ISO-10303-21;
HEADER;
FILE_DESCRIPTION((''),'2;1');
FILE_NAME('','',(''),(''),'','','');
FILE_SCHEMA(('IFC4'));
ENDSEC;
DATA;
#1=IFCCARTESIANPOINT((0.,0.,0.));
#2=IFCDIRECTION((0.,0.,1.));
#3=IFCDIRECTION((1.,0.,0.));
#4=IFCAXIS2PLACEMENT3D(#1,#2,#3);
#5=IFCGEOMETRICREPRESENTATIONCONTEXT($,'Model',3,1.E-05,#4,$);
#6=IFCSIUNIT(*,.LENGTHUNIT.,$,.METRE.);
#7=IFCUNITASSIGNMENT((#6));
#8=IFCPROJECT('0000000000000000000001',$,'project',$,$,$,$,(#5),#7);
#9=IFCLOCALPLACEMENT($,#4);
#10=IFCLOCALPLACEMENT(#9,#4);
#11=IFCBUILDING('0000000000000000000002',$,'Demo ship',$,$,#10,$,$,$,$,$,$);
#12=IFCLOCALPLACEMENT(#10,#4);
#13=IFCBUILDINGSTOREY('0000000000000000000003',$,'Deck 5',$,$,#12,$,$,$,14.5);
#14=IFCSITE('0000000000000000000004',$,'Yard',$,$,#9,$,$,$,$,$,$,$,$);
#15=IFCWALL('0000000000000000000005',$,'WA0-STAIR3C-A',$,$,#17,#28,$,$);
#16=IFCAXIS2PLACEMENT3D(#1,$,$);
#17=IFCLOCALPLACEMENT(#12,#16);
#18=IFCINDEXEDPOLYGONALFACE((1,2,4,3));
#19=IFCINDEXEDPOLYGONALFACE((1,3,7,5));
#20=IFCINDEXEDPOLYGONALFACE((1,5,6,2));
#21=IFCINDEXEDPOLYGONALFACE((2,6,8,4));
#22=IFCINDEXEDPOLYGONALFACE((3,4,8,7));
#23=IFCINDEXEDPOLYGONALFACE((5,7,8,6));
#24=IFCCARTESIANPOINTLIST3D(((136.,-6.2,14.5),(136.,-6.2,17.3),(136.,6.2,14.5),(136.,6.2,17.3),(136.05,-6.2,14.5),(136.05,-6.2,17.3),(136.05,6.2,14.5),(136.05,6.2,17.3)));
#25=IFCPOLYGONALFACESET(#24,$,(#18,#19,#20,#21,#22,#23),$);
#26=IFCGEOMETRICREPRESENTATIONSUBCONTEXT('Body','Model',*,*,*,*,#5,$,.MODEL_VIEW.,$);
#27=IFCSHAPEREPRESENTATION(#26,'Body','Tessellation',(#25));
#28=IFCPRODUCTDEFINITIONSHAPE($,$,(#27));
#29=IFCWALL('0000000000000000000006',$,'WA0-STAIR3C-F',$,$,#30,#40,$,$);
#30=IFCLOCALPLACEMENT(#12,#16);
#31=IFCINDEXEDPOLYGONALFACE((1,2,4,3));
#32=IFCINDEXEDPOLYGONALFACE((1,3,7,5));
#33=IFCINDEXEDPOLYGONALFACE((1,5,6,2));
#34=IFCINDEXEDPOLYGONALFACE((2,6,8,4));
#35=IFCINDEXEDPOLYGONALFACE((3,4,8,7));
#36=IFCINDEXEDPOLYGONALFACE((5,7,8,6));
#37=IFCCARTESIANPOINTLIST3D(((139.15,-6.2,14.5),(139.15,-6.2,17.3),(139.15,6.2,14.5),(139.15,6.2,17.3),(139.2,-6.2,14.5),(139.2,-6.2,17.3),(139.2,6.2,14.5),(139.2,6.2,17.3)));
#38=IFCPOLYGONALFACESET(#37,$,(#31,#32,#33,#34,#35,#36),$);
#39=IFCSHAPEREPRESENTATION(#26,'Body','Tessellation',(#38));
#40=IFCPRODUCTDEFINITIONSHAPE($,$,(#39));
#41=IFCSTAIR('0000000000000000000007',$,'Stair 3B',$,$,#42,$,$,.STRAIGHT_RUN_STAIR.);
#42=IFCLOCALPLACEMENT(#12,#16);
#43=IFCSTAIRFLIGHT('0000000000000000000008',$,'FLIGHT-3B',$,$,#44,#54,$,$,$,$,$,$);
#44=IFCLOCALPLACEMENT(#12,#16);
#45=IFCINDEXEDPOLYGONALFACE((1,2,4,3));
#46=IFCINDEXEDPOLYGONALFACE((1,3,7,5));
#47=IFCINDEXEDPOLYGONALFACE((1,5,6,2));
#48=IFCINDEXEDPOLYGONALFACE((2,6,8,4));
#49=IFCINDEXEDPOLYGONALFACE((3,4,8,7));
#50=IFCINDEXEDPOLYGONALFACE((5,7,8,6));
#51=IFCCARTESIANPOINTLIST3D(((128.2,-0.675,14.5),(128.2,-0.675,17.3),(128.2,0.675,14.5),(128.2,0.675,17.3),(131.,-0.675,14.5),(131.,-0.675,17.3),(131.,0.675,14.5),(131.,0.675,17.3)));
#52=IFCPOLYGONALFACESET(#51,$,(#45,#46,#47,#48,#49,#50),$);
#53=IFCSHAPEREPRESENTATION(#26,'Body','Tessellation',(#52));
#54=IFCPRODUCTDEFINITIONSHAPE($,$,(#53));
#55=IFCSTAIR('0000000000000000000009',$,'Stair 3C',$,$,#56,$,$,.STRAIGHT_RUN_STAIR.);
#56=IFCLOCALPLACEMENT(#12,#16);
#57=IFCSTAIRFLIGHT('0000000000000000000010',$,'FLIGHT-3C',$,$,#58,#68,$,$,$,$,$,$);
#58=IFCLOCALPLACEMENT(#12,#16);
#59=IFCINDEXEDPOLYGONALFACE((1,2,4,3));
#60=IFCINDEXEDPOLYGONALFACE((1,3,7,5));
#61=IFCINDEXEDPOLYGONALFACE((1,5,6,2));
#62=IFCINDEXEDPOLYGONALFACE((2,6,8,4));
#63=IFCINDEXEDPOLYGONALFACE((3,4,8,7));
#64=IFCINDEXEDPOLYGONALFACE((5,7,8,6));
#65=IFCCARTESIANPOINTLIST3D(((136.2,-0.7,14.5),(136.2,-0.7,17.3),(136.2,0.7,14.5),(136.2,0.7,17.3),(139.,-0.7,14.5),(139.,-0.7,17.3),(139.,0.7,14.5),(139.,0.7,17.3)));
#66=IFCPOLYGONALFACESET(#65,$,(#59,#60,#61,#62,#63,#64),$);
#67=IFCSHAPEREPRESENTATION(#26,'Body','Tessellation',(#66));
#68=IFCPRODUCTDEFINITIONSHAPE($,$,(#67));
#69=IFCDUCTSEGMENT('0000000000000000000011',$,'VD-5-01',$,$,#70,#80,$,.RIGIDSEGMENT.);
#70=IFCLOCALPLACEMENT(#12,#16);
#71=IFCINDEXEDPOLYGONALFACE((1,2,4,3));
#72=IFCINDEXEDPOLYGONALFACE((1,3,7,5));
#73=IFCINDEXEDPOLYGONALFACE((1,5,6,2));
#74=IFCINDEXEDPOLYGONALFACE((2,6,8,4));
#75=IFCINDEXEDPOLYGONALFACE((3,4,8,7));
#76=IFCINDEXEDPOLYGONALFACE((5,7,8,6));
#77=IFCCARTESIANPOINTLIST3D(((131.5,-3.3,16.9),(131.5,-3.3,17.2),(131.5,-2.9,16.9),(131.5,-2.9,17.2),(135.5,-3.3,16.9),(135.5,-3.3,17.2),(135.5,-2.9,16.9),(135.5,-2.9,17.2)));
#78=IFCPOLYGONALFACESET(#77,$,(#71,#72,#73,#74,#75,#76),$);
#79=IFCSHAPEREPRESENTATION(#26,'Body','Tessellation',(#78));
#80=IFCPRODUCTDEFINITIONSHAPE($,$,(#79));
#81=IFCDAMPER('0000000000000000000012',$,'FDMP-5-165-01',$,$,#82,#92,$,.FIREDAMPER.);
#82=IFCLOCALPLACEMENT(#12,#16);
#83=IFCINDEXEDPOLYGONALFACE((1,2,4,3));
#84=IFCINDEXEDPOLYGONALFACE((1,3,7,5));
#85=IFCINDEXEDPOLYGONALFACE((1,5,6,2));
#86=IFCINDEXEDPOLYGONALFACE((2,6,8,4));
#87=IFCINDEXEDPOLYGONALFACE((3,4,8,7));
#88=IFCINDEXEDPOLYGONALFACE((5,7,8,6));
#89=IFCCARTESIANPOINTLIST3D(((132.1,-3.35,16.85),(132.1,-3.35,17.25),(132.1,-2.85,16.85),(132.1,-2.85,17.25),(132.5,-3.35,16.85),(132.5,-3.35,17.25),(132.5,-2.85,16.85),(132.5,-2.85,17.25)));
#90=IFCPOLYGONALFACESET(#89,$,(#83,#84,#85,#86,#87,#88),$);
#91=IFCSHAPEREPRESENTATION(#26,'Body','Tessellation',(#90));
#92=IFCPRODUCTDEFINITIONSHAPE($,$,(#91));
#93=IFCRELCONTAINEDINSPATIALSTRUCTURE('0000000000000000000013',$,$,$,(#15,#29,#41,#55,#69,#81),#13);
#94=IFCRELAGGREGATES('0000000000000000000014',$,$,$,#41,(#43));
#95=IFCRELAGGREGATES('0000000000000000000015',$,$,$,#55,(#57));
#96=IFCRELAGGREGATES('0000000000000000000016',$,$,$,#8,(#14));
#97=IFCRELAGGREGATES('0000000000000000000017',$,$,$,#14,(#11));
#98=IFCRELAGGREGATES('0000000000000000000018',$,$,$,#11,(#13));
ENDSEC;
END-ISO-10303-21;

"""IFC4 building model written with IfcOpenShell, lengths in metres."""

from ifc_helpers import new_model, si_unit, frame, frame_2d, origin, origin_with_axes, place, context, subcontext, project, spatial, rectangle, extrude, element, aggregate, save


model = new_model("IFC4")

# Units and contexts
model_context = context("Model", 3, precision=1e-05, world=origin_with_axes())
body_context = subcontext(model_context, "Body", "Model", "MODEL_VIEW")
ifc_project = project(units=[si_unit("LENGTHUNIT", "METRE")], contexts=[model_context])

# Site, building, storey
site_placement = place(None, origin_with_axes())
site = spatial("IfcSite", under=ifc_project, at=site_placement, Name="Yard")
building_placement = place(site_placement, origin_with_axes())
building = spatial("IfcBuilding", under=site, at=building_placement, Name="Demo ship")
storey_placement = place(building_placement, origin_with_axes())
storey = spatial("IfcBuildingStorey", under=building, at=storey_placement, Name="Deck 5", Elevation=14.5)

# Walls
for number, where, z_axis, x_axis, name in (
    (1, (136.0, -6.2, 14.5), (0.0, 0.0, 1.0), (1.0, 0.0, 0.0), "WA0-STAIR3C-A"),
    (2, (139.15, -6.2, 14.5), (0.0, 0.0, 1.0), (1.0, 0.0, 0.0), "WA0-STAIR3C-F"),
):
    element("IfcWall", number, at=place(storey_placement, frame(where, z_axis=z_axis, x_axis=x_axis)), inside=storey, Name=name, context=body_context, shape_type="SweptSolid", body=[
        extrude(rectangle(XDim=0.05, YDim=12.4, at=frame_2d((0.025, 6.2))), origin(), (0.0, 0.0, 1.0), 2.8),
    ])

# Stairs, stair flights
stair_1_placement = place(storey_placement, frame((128.2, -0.675, 14.5), z_axis=(0.0, 0.0, 1.0), x_axis=(1.0, 0.0, 0.0)))
stair_1 = element("IfcStair", 3, at=stair_1_placement, inside=storey, Name="Stair 3B", PredefinedType="STRAIGHT_RUN_STAIR")
stair_flight_1_placement = place(stair_1_placement, origin_with_axes())
stair_flight_1 = element("IfcStairFlight", 4, at=stair_flight_1_placement, Name="FLIGHT-3B", context=body_context, shape_type="SweptSolid", body=[
    extrude(rectangle(XDim=2.8, YDim=1.35, at=frame_2d((1.4, 0.675))), origin(), (0.0, 0.0, 1.0), 2.8),
])
aggregate(stair_1, [stair_flight_1])
stair_2_placement = place(storey_placement, frame((136.2, -0.7, 14.5), z_axis=(0.0, 0.0, 1.0), x_axis=(1.0, 0.0, 0.0)))
stair_2 = element("IfcStair", 5, at=stair_2_placement, inside=storey, Name="Stair 3C", PredefinedType="STRAIGHT_RUN_STAIR")
stair_flight_2_placement = place(stair_2_placement, origin_with_axes())
stair_flight_2 = element("IfcStairFlight", 6, at=stair_flight_2_placement, Name="FLIGHT-3C", context=body_context, shape_type="SweptSolid", body=[
    extrude(rectangle(XDim=2.8, YDim=1.4, at=frame_2d((1.4, 0.7))), origin(), (0.0, 0.0, 1.0), 2.8),
])
aggregate(stair_2, [stair_flight_2])

# Duct segment
duct_segment_placement = place(storey_placement, frame((131.5, -3.3, 16.9), z_axis=(0.0, 0.0, 1.0), x_axis=(1.0, 0.0, 0.0)))
element("IfcDuctSegment", 7, at=duct_segment_placement, inside=storey, Name="VD-5-01", PredefinedType="RIGIDSEGMENT", context=body_context, shape_type="SweptSolid", body=[
    extrude(rectangle(XDim=4.0, YDim=0.4, at=frame_2d((2.0, 0.2))), origin(), (0.0, 0.0, 1.0), 0.3),
])

# Damper
damper_placement = place(storey_placement, frame((132.1, -3.35, 16.85), z_axis=(0.0, 0.0, 1.0), x_axis=(1.0, 0.0, 0.0)))
element("IfcDamper", 8, at=damper_placement, inside=storey, Name="FDMP-5-165-01", PredefinedType="FIREDAMPER", context=body_context, shape_type="SweptSolid", body=[
    extrude(rectangle(XDim=0.4, YDim=0.5, at=frame_2d((0.2, 0.25))), origin(), (0.0, 0.0, 1.0), 0.4),
])

save(model, "model.ifc")
